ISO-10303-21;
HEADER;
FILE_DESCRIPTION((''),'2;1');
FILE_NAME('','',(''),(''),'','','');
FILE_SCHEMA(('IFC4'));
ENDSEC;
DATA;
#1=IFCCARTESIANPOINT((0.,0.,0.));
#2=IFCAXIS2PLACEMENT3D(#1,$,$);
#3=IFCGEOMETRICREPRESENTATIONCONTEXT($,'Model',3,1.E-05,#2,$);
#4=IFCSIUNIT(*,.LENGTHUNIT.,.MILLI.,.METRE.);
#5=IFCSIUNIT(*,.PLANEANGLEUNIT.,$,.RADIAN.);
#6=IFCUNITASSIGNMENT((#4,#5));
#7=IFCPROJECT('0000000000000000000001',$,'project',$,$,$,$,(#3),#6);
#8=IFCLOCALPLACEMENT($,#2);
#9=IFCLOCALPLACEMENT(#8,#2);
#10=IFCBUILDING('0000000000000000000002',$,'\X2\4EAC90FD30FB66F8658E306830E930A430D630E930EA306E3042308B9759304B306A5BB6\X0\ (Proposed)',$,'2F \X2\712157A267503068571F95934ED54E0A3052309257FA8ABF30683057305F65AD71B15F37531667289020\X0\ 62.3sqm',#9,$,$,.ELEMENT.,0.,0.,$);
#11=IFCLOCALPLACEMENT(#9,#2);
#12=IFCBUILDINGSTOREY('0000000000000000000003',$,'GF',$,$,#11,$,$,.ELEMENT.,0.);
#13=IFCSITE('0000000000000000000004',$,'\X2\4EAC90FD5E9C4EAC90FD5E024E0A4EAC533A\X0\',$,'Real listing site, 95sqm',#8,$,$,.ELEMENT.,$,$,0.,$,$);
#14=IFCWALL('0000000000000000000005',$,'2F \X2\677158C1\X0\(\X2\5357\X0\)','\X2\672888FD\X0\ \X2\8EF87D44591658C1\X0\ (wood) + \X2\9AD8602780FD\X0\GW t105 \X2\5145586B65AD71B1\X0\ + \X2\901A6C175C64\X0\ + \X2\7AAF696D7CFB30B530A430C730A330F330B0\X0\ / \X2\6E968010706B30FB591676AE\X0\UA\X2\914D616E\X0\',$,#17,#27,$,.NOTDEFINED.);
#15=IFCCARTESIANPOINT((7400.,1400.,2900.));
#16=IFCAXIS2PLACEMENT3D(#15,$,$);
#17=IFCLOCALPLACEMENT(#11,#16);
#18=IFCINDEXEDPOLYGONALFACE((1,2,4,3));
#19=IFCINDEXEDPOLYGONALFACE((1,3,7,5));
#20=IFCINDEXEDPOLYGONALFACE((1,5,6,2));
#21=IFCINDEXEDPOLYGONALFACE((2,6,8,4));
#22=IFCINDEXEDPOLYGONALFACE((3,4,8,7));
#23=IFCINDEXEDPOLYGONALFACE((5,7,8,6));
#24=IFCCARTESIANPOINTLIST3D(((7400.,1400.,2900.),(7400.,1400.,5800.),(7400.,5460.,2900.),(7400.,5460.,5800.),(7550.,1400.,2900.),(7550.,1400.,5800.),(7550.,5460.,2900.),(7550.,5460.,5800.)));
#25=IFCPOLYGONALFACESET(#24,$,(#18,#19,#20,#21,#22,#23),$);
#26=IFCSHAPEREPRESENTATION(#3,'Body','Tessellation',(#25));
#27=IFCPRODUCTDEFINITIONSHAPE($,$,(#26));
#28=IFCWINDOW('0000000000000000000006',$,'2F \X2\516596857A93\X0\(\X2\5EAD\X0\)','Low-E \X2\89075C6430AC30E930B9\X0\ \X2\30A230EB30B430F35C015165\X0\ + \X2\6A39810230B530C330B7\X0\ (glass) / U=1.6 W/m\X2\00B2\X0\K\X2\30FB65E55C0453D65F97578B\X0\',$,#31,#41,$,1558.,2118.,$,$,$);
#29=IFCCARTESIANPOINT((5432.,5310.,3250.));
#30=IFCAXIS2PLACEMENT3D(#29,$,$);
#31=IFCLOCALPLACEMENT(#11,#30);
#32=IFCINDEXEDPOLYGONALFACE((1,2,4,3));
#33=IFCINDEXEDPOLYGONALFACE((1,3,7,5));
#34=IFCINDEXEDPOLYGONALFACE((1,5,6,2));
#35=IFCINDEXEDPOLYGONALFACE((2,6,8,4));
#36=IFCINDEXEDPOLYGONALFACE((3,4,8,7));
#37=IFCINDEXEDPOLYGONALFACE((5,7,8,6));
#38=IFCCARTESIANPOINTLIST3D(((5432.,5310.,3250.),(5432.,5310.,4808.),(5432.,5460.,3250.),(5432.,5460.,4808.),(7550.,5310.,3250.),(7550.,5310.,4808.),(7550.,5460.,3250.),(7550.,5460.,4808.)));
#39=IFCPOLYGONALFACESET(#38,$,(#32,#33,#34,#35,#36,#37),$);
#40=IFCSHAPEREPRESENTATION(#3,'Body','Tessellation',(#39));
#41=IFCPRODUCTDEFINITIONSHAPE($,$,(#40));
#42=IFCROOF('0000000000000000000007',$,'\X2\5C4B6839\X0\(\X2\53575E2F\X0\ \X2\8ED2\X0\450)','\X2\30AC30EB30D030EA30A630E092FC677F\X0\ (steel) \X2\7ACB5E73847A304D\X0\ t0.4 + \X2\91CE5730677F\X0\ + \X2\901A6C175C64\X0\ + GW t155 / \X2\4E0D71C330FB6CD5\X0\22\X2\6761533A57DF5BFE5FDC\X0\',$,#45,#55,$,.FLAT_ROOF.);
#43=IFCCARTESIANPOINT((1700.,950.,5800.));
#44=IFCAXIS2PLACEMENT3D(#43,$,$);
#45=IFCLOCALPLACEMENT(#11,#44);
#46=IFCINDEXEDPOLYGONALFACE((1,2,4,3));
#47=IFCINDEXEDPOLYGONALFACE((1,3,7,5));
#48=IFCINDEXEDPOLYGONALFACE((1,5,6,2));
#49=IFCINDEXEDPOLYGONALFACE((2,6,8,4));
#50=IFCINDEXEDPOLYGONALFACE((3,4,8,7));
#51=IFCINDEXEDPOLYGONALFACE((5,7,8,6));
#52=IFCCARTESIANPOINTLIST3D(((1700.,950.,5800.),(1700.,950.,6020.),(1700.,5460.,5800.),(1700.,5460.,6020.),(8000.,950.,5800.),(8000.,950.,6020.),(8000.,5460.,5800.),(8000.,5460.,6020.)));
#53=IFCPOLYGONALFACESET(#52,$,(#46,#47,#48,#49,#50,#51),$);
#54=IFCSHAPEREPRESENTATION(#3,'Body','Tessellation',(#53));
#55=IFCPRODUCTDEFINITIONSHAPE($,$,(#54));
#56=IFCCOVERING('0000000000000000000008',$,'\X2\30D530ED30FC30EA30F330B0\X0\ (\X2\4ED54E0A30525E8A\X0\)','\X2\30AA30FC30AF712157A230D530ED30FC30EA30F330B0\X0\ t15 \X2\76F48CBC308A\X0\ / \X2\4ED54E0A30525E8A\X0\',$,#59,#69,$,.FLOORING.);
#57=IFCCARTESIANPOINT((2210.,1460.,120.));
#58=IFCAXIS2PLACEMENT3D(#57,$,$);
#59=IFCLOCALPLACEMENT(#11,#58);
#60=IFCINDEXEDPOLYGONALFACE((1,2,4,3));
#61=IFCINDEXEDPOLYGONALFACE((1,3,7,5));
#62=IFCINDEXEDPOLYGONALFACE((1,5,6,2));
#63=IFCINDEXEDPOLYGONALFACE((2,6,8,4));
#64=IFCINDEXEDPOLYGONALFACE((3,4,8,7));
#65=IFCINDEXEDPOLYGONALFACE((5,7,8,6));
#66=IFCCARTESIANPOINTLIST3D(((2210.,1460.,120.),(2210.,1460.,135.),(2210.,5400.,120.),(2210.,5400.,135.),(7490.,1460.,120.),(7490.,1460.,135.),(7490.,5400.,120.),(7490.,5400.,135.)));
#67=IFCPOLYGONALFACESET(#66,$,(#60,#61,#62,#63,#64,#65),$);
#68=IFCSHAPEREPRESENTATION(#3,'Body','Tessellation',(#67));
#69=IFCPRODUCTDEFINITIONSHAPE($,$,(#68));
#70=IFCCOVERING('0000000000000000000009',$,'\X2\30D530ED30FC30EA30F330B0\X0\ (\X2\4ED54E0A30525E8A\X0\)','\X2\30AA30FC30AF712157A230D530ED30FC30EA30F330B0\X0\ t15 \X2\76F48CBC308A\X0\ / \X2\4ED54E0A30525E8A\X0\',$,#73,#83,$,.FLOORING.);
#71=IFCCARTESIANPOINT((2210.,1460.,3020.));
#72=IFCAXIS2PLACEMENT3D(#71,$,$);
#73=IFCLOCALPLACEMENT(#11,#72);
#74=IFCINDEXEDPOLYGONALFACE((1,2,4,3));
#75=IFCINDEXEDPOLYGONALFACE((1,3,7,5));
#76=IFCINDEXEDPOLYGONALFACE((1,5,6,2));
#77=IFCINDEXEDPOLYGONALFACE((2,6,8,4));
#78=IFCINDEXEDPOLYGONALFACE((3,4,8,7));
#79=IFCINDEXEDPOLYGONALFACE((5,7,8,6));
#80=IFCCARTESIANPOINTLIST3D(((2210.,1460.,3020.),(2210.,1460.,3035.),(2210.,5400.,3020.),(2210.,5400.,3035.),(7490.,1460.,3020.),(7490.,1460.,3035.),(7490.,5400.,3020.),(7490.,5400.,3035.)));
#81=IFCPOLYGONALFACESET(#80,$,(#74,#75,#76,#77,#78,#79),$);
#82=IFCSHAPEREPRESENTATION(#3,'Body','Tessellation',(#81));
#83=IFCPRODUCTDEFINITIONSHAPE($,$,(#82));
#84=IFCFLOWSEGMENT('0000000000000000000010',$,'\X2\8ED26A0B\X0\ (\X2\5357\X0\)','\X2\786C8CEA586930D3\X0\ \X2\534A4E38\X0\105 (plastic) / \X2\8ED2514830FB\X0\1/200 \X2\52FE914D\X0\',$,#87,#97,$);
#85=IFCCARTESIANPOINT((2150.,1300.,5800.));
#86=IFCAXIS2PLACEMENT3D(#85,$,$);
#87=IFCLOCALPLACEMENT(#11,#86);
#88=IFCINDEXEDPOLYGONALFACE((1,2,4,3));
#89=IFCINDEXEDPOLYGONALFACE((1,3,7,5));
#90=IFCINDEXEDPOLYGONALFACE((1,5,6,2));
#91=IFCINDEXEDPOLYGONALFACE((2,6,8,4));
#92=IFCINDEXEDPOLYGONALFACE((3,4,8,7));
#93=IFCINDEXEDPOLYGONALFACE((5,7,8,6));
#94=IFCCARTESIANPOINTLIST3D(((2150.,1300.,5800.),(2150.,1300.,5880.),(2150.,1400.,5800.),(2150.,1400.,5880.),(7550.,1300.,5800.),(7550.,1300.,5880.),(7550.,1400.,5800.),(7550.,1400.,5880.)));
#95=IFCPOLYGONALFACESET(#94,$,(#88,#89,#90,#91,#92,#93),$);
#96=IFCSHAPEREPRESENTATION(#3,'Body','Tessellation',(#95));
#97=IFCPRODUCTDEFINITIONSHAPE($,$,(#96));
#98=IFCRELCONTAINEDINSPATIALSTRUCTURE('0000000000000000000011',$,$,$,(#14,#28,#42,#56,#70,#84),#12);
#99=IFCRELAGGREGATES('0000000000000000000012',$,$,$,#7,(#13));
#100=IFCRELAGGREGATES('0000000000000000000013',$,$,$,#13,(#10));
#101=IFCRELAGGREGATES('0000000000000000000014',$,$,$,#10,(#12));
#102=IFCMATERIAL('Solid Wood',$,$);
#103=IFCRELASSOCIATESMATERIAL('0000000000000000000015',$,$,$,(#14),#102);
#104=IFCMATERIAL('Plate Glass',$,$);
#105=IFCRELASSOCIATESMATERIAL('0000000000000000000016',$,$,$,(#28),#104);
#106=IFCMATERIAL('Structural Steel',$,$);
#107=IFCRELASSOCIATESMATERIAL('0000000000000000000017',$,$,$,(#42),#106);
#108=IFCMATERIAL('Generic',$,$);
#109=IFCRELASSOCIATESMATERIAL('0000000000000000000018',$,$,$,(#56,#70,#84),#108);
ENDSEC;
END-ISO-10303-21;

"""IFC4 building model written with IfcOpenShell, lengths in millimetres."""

from ifc_helpers import new_model, si_unit, frame, frame_2d, origin, place, context, project, spatial, rectangle, extrude, material, element, fill, save


model = new_model("IFC4")

# Units and contexts
model_context = context("Model", 3, precision=1e-05, world=origin())
ifc_project = project(units=[si_unit("LENGTHUNIT", "METRE", prefix="MILLI"), si_unit("PLANEANGLEUNIT", "RADIAN")], contexts=[model_context])

# Site, building, storey
site_placement = place(None, origin())
site = spatial("IfcSite", under=ifc_project, at=site_placement, Name="京都府京都市上京区", ObjectType="Real listing site, 95sqm", CompositionType="ELEMENT", RefElevation=0.0)
building_placement = place(site_placement, origin())
building = spatial("IfcBuilding", under=site, at=building_placement, Name="京都・書斎とライブラリのある静かな家 (Proposed)", ObjectType="2F 無垢材と土間仕上げを基調とした断熱強化木造 62.3sqm", CompositionType="ELEMENT", ElevationOfRefHeight=0.0, ElevationOfTerrain=0.0)
storey_placement = place(building_placement, origin())
storey = spatial("IfcBuildingStorey", under=building, at=storey_placement, Name="GF", CompositionType="ELEMENT", Elevation=0.0)

# Shared definitions
ifc_material_1 = material(Name="Solid Wood")

# Wall, opening, window
ifc_material_2 = material(Name="Plate Glass")
wall_1_placement = place(storey_placement, frame((7400.0, 1400.0, 2900.0)))
wall_1 = element("IfcWall", 1, at=wall_1_placement, inside=storey, material=ifc_material_1, Name="2F 東壁(南)", Description="木製 軸組外壁 (wood) + 高性能GW t105 充填断熱 + 通気層 + 窯業系サイディング / 準耐火・外皮UA配慮", PredefinedType="NOTDEFINED", context=model_context, shape_type="SweptSolid", body=[
    extrude(rectangle(XDim=150.0, YDim=4060.0, at=frame_2d((75.0, 2030.0))), frame((7400.0, 1400.0, 2900.0)), (0.0, 0.0, 1.0), 2900.0),
])
opening_1_placement = place(storey_placement, frame((5432.0, 5310.0, 3250.0)))
opening_1 = element("IfcOpeningElement", 2, at=opening_1_placement, cuts=wall_1, PredefinedType="NOTDEFINED", context=model_context, shape_type="SweptSolid", body=[
    extrude(rectangle(XDim=2118.0, YDim=150.0, at=frame_2d((1059.0, 75.0))), frame((5432.0, 5310.0, 3250.0)), (0.0, 0.0, 1.0), 1558.0),
])
window_1_placement = place(storey_placement, frame((5432.0, 5310.0, 3250.0)))
window_1 = element("IfcWindow", 3, at=window_1_placement, inside=storey, material=ifc_material_2, Name="2F 入隅窓(庭)", Description="Low-E 複層ガラス アルゴン封入 + 樹脂サッシ (glass) / U=1.6 W/m²K・日射取得型", OverallHeight=1558.0, OverallWidth=2118.0, context=model_context, shape_type="SweptSolid", body=[
    extrude(rectangle(XDim=2118.0, YDim=150.0, at=frame_2d((1059.0, 75.0))), frame((5432.0, 5310.0, 3250.0)), (0.0, 0.0, 1.0), 1558.0),
])
fill(opening_1, window_1)

# Roof
ifc_material_3 = material(Name="Structural Steel")
for number, where, name in (
    (4, (1700.0, 950.0, 5800.0), "屋根(南帯 軒450)"),
):
    element("IfcRoof", number, at=place(storey_placement, frame(where)), inside=storey, material=ifc_material_3, Name=name, Description="ガルバリウム鋼板 (steel) 立平葺き t0.4 + 野地板 + 通気層 + GW t155 / 不燃・法22条区域対応", PredefinedType="FLAT_ROOF", context=model_context, shape_type="SweptSolid", body=[
        extrude(rectangle(XDim=6300.0, YDim=4510.0, at=frame_2d((3150.0, 2255.0))), frame((1700.0, 950.0, 5800.0)), (0.0, 0.0, 1.0), 220.0),
    ])

# Coverings
ifc_material_4 = material(Name="Generic")
covering_1_placement = place(storey_placement, frame((2210.0, 1460.0, 120.0)))
element("IfcCovering", 5, at=covering_1_placement, inside=storey, material=ifc_material_4, Name="フローリング (仕上げ床)", Description="オーク無垢フローリング t15 直貼り / 仕上げ床", PredefinedType="FLOORING", context=model_context, shape_type="SweptSolid", body=[
    extrude(rectangle(XDim=5280.0, YDim=3940.0, at=frame_2d((2640.0, 1970.0))), frame((2210.0, 1460.0, 120.0)), (0.0, 0.0, 1.0), 15.0),
])
covering_2_placement = place(storey_placement, frame((2210.0, 1460.0, 3020.0)))
element("IfcCovering", 6, at=covering_2_placement, inside=storey, material=ifc_material_4, Name="フローリング (仕上げ床)", Description="オーク無垢フローリング t15 直貼り / 仕上げ床", PredefinedType="FLOORING", context=model_context, shape_type="SweptSolid", body=[
    extrude(rectangle(XDim=5280.0, YDim=3940.0, at=frame_2d((2640.0, 1970.0))), frame((2210.0, 1460.0, 3020.0)), (0.0, 0.0, 1.0), 15.0),
])

# Flow segment
flow_segment_placement = place(storey_placement, frame((2150.0, 1300.0, 5800.0)))
element("IfcFlowSegment", 7, at=flow_segment_placement, inside=storey, material=ifc_material_4, Name="軒樋 (南)", Description="硬質塩ビ 半丸105 (plastic) / 軒先・1/200 勾配", context=model_context, shape_type="SweptSolid", body=[
    extrude(rectangle(XDim=5400.0, YDim=100.0, at=frame_2d((2700.0, 50.0))), frame((2150.0, 1300.0, 5800.0)), (0.0, 0.0, 1.0), 80.0),
])

save(model, "model.ifc")
